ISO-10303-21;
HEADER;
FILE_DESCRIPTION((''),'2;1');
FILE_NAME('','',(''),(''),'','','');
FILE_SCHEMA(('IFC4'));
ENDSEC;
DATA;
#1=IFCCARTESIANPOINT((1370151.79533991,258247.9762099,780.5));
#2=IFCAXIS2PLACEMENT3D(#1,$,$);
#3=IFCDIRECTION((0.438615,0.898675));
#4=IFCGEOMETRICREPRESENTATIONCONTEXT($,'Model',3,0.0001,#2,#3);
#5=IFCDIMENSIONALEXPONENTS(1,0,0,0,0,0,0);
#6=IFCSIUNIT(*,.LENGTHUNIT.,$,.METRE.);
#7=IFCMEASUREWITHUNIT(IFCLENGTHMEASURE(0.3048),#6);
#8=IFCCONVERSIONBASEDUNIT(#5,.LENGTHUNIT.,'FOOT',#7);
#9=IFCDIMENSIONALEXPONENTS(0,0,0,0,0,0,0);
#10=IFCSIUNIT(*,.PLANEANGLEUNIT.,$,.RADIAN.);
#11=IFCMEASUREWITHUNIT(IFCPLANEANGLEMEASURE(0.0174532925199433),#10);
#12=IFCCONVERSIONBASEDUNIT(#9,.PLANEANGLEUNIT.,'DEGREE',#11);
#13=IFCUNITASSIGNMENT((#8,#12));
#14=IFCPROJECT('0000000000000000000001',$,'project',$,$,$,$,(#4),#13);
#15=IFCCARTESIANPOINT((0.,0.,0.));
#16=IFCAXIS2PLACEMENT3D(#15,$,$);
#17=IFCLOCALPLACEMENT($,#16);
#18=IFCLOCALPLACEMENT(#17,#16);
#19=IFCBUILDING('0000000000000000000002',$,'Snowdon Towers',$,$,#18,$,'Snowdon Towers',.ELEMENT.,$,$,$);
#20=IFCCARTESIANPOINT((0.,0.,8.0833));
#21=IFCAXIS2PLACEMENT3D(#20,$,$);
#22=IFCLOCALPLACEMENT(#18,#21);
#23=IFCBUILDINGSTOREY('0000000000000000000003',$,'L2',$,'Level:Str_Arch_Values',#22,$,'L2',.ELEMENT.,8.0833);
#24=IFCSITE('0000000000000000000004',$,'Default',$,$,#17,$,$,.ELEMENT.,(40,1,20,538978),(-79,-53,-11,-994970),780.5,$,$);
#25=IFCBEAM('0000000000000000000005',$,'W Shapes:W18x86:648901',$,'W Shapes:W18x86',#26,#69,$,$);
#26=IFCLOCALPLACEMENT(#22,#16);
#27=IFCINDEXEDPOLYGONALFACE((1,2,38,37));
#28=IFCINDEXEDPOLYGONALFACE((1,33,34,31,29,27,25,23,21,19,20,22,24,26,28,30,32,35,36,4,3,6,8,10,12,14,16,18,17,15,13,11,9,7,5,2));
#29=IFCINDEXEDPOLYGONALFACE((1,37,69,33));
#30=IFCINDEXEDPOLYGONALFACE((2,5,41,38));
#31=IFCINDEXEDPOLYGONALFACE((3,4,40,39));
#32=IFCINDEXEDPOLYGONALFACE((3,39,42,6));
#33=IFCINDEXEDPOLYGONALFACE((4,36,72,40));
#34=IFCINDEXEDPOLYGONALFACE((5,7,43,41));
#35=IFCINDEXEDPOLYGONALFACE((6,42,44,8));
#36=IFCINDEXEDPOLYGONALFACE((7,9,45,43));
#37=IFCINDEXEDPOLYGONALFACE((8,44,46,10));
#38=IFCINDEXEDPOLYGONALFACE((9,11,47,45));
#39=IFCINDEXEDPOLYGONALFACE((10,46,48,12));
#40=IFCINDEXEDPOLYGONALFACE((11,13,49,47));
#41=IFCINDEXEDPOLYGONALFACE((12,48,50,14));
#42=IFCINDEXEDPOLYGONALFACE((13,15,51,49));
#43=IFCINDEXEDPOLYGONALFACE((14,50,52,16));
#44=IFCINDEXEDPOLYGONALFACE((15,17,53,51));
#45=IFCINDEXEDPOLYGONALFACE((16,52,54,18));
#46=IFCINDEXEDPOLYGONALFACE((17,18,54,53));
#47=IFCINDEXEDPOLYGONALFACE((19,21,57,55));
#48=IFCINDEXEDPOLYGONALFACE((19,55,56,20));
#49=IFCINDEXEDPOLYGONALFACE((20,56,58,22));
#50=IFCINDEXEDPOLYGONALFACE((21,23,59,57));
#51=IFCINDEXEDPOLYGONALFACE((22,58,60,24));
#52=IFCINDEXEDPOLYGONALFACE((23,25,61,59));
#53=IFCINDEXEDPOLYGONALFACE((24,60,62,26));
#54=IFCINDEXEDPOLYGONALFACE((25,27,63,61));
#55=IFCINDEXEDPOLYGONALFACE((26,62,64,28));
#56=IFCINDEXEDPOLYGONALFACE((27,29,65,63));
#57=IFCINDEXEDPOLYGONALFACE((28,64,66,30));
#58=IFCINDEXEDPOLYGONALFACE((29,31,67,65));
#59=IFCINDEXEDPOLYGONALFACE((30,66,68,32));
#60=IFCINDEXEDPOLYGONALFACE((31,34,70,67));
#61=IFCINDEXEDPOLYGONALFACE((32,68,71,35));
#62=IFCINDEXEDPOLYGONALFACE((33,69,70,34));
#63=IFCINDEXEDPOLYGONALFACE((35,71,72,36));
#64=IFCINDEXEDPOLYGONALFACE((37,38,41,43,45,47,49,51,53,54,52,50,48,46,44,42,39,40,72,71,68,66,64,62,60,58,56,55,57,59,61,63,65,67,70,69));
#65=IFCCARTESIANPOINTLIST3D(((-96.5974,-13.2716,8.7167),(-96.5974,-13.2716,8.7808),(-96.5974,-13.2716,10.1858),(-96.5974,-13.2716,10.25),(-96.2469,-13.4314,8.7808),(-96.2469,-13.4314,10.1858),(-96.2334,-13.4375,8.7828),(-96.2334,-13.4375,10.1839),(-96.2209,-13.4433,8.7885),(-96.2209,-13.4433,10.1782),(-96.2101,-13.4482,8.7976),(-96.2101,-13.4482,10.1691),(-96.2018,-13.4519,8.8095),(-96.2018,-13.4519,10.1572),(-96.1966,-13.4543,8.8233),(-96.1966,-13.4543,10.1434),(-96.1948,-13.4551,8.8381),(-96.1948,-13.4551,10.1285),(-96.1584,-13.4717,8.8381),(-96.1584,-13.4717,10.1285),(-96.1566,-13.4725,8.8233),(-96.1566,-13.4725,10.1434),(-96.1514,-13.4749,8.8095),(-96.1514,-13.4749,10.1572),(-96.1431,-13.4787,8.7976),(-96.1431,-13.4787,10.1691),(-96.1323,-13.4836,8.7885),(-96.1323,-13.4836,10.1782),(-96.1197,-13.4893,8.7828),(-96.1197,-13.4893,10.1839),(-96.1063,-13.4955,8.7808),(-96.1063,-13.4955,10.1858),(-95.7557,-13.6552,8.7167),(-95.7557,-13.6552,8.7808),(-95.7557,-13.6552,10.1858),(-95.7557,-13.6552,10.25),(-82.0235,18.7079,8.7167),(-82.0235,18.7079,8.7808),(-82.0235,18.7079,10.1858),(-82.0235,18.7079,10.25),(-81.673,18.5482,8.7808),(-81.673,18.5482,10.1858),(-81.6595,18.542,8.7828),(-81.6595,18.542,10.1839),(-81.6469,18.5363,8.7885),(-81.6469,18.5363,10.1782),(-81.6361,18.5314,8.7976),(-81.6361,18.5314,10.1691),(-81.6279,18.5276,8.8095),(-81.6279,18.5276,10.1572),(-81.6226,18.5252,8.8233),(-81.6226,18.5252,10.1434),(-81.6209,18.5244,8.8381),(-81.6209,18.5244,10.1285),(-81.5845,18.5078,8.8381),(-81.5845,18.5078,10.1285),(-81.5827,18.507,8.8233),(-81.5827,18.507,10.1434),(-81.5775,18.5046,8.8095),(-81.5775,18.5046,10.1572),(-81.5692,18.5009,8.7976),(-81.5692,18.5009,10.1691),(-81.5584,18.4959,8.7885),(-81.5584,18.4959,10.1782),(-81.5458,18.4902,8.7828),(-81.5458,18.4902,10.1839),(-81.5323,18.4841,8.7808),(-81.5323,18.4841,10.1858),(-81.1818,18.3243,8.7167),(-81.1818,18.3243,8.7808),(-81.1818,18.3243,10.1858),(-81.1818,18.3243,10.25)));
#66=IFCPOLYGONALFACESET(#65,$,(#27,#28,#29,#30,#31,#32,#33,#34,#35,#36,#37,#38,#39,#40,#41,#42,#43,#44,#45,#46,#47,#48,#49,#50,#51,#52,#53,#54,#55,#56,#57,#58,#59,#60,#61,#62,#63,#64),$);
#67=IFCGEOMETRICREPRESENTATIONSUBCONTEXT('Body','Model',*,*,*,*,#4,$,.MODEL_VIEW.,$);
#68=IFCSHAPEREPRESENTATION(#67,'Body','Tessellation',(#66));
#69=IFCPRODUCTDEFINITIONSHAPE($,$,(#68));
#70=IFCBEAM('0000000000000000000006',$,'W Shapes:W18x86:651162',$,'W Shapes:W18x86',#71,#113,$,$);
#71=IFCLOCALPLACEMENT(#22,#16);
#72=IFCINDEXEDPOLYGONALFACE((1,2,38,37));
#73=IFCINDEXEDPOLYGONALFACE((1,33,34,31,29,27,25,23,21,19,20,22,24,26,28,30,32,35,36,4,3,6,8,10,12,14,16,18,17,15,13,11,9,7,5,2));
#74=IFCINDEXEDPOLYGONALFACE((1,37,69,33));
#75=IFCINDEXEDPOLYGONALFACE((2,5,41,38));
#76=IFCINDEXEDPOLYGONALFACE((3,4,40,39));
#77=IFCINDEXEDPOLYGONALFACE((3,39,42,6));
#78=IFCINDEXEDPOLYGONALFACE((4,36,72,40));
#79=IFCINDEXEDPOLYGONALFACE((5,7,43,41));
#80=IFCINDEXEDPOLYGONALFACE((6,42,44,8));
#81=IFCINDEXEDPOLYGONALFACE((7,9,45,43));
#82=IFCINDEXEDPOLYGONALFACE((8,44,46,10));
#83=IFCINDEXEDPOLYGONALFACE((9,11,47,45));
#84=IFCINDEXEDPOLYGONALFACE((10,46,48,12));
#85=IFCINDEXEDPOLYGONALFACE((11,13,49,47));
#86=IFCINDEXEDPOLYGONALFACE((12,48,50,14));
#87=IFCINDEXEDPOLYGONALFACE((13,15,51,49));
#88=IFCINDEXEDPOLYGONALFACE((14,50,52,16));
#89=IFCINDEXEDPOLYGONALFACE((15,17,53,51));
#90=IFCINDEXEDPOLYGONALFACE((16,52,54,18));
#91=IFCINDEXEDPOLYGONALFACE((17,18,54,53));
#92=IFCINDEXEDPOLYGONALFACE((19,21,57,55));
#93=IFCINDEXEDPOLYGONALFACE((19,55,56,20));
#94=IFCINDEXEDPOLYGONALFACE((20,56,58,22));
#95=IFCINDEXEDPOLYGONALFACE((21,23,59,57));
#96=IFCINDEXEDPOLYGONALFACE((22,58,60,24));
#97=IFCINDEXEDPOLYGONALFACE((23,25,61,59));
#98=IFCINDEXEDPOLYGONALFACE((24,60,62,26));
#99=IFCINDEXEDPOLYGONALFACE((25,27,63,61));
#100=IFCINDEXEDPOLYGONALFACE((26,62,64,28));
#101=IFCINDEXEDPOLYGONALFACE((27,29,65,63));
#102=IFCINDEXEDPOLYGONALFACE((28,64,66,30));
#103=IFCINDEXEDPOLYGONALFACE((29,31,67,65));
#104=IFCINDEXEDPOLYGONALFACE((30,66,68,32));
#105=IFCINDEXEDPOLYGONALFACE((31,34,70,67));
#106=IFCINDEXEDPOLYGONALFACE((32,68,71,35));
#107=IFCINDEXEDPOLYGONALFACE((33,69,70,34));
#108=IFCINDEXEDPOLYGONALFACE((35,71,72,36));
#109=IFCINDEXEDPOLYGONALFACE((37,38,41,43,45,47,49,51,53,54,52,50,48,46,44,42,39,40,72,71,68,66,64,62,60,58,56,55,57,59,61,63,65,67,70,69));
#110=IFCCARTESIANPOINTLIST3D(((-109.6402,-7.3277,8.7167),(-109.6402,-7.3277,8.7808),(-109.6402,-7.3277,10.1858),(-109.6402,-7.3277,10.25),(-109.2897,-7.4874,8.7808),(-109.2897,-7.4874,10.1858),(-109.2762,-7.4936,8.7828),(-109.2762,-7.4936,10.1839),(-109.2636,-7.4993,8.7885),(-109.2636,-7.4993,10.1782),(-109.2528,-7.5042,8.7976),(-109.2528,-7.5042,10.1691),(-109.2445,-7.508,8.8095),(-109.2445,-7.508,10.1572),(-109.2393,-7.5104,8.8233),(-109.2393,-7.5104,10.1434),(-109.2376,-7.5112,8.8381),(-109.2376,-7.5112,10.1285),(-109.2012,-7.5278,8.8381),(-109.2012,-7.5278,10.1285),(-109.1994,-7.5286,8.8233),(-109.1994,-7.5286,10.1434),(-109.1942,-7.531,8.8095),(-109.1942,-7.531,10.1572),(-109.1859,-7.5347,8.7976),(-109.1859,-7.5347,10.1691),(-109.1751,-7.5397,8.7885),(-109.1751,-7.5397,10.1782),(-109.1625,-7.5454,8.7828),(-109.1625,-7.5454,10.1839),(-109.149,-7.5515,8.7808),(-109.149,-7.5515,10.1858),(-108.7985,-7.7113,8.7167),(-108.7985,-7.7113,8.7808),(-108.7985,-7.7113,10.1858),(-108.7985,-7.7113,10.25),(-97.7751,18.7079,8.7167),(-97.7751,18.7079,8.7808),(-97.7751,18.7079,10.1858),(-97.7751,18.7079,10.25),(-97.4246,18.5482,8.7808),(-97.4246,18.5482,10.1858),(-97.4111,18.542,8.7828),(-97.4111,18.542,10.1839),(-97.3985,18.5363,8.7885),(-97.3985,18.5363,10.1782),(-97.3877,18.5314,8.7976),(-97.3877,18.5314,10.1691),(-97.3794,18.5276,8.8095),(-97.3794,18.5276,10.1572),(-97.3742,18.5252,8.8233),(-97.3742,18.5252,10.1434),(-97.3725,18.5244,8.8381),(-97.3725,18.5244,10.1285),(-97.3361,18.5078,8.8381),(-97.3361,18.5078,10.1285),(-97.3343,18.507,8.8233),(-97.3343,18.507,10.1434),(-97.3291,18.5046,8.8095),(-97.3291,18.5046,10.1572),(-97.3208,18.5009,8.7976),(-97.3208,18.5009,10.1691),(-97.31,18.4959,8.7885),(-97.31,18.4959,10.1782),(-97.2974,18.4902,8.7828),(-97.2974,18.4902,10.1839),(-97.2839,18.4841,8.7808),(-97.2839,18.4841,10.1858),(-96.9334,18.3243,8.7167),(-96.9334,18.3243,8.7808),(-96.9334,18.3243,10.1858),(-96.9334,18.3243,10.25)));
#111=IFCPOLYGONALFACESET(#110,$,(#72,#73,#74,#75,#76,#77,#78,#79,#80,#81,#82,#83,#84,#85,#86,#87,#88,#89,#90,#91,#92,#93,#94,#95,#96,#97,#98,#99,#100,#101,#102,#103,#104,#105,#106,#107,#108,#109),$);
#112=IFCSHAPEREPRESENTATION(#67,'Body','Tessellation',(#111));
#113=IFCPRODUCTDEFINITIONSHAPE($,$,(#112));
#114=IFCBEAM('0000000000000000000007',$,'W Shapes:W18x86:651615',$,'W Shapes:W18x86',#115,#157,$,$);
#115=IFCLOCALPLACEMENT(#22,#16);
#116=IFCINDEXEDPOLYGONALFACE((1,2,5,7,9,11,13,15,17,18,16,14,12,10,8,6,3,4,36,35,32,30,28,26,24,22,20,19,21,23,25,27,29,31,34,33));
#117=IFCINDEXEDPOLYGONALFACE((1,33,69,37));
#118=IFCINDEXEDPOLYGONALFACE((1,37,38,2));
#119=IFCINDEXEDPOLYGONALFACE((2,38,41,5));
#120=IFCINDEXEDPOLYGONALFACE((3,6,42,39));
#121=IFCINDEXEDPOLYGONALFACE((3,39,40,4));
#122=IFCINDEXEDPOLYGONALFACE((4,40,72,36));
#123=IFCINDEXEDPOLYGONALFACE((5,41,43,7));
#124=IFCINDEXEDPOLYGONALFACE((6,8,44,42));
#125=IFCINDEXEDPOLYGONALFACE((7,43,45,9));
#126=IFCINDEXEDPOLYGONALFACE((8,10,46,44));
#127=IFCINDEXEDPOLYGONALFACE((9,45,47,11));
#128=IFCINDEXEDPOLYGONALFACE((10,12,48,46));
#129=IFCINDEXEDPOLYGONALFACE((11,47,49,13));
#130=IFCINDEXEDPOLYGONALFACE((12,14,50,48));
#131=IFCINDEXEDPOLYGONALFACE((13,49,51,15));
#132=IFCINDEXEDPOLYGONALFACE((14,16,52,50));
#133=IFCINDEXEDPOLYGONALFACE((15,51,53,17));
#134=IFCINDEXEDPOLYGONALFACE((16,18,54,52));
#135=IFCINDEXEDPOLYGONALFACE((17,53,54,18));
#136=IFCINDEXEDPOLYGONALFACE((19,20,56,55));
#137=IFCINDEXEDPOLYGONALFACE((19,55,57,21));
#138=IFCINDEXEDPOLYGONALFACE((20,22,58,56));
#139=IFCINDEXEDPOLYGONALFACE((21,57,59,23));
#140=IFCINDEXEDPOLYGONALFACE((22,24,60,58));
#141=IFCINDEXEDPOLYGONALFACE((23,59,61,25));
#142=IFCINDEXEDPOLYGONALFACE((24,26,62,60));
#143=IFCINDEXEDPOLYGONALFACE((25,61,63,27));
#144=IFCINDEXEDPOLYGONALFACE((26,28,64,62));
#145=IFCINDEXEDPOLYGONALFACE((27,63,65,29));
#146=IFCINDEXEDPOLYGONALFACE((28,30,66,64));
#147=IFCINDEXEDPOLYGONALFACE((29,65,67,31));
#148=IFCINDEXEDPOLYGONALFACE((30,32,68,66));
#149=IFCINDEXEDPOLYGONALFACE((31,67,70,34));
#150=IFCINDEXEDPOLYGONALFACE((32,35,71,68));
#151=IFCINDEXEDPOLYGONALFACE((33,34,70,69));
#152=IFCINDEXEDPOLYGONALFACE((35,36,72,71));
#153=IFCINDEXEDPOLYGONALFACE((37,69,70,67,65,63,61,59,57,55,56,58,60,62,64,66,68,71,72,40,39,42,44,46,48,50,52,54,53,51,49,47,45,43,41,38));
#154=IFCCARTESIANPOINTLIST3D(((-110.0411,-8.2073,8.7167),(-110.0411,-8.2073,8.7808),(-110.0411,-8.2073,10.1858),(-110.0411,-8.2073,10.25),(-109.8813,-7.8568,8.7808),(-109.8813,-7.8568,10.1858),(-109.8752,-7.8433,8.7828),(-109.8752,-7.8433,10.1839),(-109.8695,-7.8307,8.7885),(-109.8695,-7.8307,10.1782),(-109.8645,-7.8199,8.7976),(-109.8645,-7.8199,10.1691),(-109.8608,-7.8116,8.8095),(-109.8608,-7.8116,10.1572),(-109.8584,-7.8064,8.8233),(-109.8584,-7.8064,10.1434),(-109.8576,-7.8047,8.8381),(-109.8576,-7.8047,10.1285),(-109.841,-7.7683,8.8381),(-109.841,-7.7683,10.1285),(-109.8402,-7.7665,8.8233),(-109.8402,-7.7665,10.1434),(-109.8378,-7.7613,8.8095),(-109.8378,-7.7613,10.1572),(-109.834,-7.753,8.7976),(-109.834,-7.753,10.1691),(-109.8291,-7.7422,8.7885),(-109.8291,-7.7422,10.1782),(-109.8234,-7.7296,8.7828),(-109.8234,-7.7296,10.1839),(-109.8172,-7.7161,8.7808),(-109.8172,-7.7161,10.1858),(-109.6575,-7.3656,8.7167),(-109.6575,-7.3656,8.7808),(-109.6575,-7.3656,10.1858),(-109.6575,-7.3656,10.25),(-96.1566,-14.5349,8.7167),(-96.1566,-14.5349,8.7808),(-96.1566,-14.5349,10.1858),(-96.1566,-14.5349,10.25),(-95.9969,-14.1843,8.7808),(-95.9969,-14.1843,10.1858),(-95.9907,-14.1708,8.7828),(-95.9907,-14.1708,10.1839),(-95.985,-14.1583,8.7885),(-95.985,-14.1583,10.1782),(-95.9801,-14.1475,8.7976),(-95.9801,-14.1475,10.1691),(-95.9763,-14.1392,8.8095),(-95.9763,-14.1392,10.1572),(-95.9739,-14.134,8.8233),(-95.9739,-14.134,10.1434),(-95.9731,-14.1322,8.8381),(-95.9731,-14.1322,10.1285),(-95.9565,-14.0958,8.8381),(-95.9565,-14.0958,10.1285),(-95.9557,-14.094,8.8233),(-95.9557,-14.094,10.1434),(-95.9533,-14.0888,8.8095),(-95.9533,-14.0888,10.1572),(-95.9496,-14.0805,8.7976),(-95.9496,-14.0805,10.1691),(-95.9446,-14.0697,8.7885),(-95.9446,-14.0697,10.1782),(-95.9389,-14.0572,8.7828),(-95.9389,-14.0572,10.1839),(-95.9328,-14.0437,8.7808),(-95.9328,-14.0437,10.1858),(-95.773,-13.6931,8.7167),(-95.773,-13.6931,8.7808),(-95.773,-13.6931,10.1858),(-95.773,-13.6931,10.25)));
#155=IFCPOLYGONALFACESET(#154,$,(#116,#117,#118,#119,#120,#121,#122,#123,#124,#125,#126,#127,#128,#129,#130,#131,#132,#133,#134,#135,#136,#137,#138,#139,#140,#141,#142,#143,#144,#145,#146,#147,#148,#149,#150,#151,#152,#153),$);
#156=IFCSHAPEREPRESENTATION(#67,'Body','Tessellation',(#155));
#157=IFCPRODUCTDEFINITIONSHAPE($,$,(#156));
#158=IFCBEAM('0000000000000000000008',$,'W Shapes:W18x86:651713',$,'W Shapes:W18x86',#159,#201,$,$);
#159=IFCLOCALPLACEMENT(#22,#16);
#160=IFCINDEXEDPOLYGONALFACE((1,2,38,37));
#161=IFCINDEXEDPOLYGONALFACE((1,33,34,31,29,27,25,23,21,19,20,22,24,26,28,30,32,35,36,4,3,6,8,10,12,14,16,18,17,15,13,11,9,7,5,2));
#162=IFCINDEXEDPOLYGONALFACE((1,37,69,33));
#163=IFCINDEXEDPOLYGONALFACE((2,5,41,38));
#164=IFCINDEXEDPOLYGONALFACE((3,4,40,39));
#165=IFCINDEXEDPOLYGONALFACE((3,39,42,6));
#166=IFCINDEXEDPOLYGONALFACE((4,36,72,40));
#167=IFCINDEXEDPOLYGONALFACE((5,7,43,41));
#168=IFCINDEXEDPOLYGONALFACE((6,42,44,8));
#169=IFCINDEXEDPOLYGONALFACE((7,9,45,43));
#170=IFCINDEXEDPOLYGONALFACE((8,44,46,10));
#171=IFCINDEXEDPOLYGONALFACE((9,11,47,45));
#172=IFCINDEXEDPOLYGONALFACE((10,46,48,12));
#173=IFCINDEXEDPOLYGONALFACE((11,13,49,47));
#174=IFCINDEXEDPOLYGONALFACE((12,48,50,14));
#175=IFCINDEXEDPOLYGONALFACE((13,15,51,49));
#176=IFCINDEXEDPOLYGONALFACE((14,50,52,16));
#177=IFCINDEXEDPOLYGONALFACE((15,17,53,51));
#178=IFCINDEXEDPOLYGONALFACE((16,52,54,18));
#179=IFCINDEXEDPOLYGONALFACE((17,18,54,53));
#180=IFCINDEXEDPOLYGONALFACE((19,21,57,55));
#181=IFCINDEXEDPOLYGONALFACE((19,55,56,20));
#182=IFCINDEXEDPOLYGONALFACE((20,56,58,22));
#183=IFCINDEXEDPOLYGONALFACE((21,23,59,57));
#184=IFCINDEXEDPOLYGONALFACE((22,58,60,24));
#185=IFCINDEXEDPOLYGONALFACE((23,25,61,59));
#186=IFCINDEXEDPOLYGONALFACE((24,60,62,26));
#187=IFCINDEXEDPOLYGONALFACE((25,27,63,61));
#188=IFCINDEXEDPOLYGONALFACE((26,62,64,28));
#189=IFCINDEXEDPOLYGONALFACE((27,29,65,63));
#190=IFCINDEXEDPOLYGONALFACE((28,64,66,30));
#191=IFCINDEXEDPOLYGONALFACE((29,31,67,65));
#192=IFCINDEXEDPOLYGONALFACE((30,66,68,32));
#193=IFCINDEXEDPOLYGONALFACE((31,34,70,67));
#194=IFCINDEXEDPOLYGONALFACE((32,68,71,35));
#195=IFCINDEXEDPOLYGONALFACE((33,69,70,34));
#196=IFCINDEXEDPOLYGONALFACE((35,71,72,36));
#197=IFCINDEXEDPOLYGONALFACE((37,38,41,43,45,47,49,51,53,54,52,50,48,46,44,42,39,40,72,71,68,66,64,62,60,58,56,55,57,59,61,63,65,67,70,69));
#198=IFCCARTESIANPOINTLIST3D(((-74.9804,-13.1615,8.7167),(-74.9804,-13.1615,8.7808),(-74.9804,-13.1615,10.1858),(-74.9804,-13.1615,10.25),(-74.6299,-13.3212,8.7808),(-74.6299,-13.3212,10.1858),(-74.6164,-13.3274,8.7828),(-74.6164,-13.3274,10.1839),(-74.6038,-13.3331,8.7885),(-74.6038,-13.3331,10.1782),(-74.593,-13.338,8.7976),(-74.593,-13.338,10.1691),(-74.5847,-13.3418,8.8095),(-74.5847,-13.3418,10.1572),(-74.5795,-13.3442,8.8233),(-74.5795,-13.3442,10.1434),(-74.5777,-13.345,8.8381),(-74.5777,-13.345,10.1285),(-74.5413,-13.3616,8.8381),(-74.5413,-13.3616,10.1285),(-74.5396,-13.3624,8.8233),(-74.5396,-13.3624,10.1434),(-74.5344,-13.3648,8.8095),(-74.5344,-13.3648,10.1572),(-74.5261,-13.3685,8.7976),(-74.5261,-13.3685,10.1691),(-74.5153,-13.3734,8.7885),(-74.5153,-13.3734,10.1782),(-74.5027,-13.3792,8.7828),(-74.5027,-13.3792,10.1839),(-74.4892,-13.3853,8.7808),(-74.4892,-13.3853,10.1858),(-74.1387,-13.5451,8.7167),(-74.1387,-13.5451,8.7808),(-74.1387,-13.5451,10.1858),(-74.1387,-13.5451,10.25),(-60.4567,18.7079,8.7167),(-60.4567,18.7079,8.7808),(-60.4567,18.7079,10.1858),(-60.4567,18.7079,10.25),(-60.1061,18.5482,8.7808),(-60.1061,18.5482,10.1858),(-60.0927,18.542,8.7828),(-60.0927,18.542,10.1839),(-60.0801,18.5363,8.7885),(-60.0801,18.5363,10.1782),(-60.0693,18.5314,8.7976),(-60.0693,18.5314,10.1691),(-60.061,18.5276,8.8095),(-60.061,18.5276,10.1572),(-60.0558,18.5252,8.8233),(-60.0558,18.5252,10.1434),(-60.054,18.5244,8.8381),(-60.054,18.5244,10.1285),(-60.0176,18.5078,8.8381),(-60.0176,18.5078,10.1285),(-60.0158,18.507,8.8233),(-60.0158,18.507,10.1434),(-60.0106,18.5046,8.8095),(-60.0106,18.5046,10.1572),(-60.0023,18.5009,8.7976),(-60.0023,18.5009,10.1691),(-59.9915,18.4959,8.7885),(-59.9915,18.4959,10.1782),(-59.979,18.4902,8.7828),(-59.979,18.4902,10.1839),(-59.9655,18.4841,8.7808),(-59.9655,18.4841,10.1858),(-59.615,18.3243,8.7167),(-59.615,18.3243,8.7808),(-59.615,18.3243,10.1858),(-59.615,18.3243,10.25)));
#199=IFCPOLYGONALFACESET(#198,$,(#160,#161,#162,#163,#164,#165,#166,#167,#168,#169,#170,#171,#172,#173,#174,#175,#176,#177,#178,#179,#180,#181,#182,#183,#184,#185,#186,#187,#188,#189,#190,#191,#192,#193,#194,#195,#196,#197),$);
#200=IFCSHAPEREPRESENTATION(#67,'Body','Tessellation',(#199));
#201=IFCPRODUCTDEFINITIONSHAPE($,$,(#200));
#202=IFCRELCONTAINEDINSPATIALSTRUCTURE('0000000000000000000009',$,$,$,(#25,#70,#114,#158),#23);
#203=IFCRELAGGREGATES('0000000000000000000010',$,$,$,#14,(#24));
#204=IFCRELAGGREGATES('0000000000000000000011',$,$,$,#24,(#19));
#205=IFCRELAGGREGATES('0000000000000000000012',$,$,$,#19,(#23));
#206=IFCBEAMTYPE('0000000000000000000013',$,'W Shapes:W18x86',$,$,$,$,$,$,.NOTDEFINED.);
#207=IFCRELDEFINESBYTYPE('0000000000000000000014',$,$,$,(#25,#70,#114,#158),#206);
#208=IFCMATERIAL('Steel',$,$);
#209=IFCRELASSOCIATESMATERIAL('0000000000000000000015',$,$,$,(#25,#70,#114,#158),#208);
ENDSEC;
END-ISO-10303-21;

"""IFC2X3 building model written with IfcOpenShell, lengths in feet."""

from ifc_helpers import new_model, entity, si_unit, converted_unit, direction, frame, frame_2d, origin, place, context, subcontext, project, spatial, i_section, extrude, material, type_object, element, save


model = new_model("IFC2X3")

# Units and contexts
model_context = context("Model", 3, precision=0.0001, world=frame((1370151.79533991, 258247.9762099, 780.5)), true_north=direction((0.438615, 0.898675)))
body_context = subcontext(model_context, "Body", "Model", "MODEL_VIEW")
ifc_project = project(units=[converted_unit("LENGTHUNIT", "FOOT", entity("IfcLengthMeasure", 0.3048), si_unit("LENGTHUNIT", "METRE"), dimensions=[1, 0, 0, 0, 0, 0, 0]), converted_unit("PLANEANGLEUNIT", "DEGREE", entity("IfcPlaneAngleMeasure", 0.0174532925199433), si_unit("PLANEANGLEUNIT", "RADIAN"), dimensions=[0, 0, 0, 0, 0, 0, 0])], contexts=[model_context])

# Site, building, storey
site_placement = place(None, origin())
site = spatial("IfcSite", under=ifc_project, at=site_placement, Name="Default", CompositionType="ELEMENT", RefLatitude=(40, 1, 20, 538978), RefLongitude=(-79, -53, -11, -994970), RefElevation=780.5)
building_placement = place(site_placement, origin())
building = spatial("IfcBuilding", under=site, at=building_placement, Name="Snowdon Towers", LongName="Snowdon Towers", CompositionType="ELEMENT")
storey_placement = place(building_placement, frame((0.0, 0.0, 8.0833)))
storey = spatial("IfcBuildingStorey", under=building, at=storey_placement, Name="L2", ObjectType="Level:Str_Arch_Values", LongName="L2", CompositionType="ELEMENT", Elevation=8.0833)

# Shared definitions
ifc_material_1 = material(Name="Steel")

# Beams
beam_type_1 = type_object("IfcBeamType", Name="W Shapes:W18x86", PredefinedType="NOTDEFINED")
beam_1_placement = place(storey_placement, frame((-96.3857, -13.9222, 10.25), z_axis=(0.0, 0.0, 1.0), x_axis=(0.414693, 0.909961, 0.0)))
element("IfcBeam", 1, at=beam_1_placement, inside=storey, type_object=beam_type_1, material=ifc_material_1, Name="W Shapes:W18x86:648901", ObjectType="W Shapes:W18x86", context=body_context, shape_type="SweptSolid", body=[
    extrude(i_section(OverallWidth=0.925, OverallDepth=1.5333, WebThickness=0.04, FlangeThickness=0.0642, FilletRadius=0.0573, at=frame_2d((0.0, 0.0), x_axis=(0.0, 1.0))), frame((0.5042, 0.0, -0.7667), z_axis=(1.0, 0.0, 0.0), x_axis=(0.0, 0.0, -1.0)), (0.0, 0.0, 1.0), 35.1439),
])
beam_2_placement = place(storey_placement, frame((-109.4284, -7.9783, 10.25), z_axis=(0.0, 0.0, 1.0), x_axis=(0.414693, 0.909961, 0.0)))
element("IfcBeam", 2, at=beam_2_placement, inside=storey, type_object=beam_type_1, material=ifc_material_1, Name="W Shapes:W18x86:651162", ObjectType="W Shapes:W18x86", context=body_context, shape_type="SweptSolid", body=[
    extrude(i_section(OverallWidth=0.925, OverallDepth=1.5333, WebThickness=0.04, FlangeThickness=0.0642, FilletRadius=0.0573, at=frame_2d((0.0, 0.0), x_axis=(0.0, 1.0))), frame((0.5042, 0.0, -0.7667), z_axis=(1.0, 0.0, 0.0), x_axis=(0.0, 0.0, -1.0)), (0.0, 0.0, 1.0), 28.6118),
])
beam_3_placement = place(storey_placement, frame((-109.4284, -7.9783, 10.25), z_axis=(0.0, 0.0, 1.0), x_axis=(0.909961, -0.414693, 0.0)))
element("IfcBeam", 3, at=beam_3_placement, inside=storey, type_object=beam_type_1, material=ifc_material_1, Name="W Shapes:W18x86:651615", ObjectType="W Shapes:W18x86", context=body_context, shape_type="SweptSolid", body=[
    extrude(i_section(OverallWidth=0.925, OverallDepth=1.5333, WebThickness=0.04, FlangeThickness=0.0642, FilletRadius=0.0573, at=frame_2d((0.0, 0.0), x_axis=(0.0, 1.0))), frame((-0.4625, 0.0, -0.7667), z_axis=(1.0, 0.0, 0.0), x_axis=(0.0, 0.0, -1.0)), (0.0, 0.0, 1.0), 15.2583),
])
beam_4_placement = place(storey_placement, frame((-74.7686, -13.812, 10.25), z_axis=(0.0, 0.0, 1.0), x_axis=(0.414693, 0.909961, 0.0)))
element("IfcBeam", 4, at=beam_4_placement, inside=storey, type_object=beam_type_1, material=ifc_material_1, Name="W Shapes:W18x86:651713", ObjectType="W Shapes:W18x86", context=body_context, shape_type="SweptSolid", body=[
    extrude(i_section(OverallWidth=0.925, OverallDepth=1.5333, WebThickness=0.04, FlangeThickness=0.0642, FilletRadius=0.0573, at=frame_2d((0.0, 0.0), x_axis=(0.0, 1.0))), frame((0.5042, 0.0, -0.7667), z_axis=(1.0, 0.0, 0.0), x_axis=(0.0, 0.0, -1.0)), (0.0, 0.0, 1.0), 35.0228),
])

save(model, "model.ifc")
